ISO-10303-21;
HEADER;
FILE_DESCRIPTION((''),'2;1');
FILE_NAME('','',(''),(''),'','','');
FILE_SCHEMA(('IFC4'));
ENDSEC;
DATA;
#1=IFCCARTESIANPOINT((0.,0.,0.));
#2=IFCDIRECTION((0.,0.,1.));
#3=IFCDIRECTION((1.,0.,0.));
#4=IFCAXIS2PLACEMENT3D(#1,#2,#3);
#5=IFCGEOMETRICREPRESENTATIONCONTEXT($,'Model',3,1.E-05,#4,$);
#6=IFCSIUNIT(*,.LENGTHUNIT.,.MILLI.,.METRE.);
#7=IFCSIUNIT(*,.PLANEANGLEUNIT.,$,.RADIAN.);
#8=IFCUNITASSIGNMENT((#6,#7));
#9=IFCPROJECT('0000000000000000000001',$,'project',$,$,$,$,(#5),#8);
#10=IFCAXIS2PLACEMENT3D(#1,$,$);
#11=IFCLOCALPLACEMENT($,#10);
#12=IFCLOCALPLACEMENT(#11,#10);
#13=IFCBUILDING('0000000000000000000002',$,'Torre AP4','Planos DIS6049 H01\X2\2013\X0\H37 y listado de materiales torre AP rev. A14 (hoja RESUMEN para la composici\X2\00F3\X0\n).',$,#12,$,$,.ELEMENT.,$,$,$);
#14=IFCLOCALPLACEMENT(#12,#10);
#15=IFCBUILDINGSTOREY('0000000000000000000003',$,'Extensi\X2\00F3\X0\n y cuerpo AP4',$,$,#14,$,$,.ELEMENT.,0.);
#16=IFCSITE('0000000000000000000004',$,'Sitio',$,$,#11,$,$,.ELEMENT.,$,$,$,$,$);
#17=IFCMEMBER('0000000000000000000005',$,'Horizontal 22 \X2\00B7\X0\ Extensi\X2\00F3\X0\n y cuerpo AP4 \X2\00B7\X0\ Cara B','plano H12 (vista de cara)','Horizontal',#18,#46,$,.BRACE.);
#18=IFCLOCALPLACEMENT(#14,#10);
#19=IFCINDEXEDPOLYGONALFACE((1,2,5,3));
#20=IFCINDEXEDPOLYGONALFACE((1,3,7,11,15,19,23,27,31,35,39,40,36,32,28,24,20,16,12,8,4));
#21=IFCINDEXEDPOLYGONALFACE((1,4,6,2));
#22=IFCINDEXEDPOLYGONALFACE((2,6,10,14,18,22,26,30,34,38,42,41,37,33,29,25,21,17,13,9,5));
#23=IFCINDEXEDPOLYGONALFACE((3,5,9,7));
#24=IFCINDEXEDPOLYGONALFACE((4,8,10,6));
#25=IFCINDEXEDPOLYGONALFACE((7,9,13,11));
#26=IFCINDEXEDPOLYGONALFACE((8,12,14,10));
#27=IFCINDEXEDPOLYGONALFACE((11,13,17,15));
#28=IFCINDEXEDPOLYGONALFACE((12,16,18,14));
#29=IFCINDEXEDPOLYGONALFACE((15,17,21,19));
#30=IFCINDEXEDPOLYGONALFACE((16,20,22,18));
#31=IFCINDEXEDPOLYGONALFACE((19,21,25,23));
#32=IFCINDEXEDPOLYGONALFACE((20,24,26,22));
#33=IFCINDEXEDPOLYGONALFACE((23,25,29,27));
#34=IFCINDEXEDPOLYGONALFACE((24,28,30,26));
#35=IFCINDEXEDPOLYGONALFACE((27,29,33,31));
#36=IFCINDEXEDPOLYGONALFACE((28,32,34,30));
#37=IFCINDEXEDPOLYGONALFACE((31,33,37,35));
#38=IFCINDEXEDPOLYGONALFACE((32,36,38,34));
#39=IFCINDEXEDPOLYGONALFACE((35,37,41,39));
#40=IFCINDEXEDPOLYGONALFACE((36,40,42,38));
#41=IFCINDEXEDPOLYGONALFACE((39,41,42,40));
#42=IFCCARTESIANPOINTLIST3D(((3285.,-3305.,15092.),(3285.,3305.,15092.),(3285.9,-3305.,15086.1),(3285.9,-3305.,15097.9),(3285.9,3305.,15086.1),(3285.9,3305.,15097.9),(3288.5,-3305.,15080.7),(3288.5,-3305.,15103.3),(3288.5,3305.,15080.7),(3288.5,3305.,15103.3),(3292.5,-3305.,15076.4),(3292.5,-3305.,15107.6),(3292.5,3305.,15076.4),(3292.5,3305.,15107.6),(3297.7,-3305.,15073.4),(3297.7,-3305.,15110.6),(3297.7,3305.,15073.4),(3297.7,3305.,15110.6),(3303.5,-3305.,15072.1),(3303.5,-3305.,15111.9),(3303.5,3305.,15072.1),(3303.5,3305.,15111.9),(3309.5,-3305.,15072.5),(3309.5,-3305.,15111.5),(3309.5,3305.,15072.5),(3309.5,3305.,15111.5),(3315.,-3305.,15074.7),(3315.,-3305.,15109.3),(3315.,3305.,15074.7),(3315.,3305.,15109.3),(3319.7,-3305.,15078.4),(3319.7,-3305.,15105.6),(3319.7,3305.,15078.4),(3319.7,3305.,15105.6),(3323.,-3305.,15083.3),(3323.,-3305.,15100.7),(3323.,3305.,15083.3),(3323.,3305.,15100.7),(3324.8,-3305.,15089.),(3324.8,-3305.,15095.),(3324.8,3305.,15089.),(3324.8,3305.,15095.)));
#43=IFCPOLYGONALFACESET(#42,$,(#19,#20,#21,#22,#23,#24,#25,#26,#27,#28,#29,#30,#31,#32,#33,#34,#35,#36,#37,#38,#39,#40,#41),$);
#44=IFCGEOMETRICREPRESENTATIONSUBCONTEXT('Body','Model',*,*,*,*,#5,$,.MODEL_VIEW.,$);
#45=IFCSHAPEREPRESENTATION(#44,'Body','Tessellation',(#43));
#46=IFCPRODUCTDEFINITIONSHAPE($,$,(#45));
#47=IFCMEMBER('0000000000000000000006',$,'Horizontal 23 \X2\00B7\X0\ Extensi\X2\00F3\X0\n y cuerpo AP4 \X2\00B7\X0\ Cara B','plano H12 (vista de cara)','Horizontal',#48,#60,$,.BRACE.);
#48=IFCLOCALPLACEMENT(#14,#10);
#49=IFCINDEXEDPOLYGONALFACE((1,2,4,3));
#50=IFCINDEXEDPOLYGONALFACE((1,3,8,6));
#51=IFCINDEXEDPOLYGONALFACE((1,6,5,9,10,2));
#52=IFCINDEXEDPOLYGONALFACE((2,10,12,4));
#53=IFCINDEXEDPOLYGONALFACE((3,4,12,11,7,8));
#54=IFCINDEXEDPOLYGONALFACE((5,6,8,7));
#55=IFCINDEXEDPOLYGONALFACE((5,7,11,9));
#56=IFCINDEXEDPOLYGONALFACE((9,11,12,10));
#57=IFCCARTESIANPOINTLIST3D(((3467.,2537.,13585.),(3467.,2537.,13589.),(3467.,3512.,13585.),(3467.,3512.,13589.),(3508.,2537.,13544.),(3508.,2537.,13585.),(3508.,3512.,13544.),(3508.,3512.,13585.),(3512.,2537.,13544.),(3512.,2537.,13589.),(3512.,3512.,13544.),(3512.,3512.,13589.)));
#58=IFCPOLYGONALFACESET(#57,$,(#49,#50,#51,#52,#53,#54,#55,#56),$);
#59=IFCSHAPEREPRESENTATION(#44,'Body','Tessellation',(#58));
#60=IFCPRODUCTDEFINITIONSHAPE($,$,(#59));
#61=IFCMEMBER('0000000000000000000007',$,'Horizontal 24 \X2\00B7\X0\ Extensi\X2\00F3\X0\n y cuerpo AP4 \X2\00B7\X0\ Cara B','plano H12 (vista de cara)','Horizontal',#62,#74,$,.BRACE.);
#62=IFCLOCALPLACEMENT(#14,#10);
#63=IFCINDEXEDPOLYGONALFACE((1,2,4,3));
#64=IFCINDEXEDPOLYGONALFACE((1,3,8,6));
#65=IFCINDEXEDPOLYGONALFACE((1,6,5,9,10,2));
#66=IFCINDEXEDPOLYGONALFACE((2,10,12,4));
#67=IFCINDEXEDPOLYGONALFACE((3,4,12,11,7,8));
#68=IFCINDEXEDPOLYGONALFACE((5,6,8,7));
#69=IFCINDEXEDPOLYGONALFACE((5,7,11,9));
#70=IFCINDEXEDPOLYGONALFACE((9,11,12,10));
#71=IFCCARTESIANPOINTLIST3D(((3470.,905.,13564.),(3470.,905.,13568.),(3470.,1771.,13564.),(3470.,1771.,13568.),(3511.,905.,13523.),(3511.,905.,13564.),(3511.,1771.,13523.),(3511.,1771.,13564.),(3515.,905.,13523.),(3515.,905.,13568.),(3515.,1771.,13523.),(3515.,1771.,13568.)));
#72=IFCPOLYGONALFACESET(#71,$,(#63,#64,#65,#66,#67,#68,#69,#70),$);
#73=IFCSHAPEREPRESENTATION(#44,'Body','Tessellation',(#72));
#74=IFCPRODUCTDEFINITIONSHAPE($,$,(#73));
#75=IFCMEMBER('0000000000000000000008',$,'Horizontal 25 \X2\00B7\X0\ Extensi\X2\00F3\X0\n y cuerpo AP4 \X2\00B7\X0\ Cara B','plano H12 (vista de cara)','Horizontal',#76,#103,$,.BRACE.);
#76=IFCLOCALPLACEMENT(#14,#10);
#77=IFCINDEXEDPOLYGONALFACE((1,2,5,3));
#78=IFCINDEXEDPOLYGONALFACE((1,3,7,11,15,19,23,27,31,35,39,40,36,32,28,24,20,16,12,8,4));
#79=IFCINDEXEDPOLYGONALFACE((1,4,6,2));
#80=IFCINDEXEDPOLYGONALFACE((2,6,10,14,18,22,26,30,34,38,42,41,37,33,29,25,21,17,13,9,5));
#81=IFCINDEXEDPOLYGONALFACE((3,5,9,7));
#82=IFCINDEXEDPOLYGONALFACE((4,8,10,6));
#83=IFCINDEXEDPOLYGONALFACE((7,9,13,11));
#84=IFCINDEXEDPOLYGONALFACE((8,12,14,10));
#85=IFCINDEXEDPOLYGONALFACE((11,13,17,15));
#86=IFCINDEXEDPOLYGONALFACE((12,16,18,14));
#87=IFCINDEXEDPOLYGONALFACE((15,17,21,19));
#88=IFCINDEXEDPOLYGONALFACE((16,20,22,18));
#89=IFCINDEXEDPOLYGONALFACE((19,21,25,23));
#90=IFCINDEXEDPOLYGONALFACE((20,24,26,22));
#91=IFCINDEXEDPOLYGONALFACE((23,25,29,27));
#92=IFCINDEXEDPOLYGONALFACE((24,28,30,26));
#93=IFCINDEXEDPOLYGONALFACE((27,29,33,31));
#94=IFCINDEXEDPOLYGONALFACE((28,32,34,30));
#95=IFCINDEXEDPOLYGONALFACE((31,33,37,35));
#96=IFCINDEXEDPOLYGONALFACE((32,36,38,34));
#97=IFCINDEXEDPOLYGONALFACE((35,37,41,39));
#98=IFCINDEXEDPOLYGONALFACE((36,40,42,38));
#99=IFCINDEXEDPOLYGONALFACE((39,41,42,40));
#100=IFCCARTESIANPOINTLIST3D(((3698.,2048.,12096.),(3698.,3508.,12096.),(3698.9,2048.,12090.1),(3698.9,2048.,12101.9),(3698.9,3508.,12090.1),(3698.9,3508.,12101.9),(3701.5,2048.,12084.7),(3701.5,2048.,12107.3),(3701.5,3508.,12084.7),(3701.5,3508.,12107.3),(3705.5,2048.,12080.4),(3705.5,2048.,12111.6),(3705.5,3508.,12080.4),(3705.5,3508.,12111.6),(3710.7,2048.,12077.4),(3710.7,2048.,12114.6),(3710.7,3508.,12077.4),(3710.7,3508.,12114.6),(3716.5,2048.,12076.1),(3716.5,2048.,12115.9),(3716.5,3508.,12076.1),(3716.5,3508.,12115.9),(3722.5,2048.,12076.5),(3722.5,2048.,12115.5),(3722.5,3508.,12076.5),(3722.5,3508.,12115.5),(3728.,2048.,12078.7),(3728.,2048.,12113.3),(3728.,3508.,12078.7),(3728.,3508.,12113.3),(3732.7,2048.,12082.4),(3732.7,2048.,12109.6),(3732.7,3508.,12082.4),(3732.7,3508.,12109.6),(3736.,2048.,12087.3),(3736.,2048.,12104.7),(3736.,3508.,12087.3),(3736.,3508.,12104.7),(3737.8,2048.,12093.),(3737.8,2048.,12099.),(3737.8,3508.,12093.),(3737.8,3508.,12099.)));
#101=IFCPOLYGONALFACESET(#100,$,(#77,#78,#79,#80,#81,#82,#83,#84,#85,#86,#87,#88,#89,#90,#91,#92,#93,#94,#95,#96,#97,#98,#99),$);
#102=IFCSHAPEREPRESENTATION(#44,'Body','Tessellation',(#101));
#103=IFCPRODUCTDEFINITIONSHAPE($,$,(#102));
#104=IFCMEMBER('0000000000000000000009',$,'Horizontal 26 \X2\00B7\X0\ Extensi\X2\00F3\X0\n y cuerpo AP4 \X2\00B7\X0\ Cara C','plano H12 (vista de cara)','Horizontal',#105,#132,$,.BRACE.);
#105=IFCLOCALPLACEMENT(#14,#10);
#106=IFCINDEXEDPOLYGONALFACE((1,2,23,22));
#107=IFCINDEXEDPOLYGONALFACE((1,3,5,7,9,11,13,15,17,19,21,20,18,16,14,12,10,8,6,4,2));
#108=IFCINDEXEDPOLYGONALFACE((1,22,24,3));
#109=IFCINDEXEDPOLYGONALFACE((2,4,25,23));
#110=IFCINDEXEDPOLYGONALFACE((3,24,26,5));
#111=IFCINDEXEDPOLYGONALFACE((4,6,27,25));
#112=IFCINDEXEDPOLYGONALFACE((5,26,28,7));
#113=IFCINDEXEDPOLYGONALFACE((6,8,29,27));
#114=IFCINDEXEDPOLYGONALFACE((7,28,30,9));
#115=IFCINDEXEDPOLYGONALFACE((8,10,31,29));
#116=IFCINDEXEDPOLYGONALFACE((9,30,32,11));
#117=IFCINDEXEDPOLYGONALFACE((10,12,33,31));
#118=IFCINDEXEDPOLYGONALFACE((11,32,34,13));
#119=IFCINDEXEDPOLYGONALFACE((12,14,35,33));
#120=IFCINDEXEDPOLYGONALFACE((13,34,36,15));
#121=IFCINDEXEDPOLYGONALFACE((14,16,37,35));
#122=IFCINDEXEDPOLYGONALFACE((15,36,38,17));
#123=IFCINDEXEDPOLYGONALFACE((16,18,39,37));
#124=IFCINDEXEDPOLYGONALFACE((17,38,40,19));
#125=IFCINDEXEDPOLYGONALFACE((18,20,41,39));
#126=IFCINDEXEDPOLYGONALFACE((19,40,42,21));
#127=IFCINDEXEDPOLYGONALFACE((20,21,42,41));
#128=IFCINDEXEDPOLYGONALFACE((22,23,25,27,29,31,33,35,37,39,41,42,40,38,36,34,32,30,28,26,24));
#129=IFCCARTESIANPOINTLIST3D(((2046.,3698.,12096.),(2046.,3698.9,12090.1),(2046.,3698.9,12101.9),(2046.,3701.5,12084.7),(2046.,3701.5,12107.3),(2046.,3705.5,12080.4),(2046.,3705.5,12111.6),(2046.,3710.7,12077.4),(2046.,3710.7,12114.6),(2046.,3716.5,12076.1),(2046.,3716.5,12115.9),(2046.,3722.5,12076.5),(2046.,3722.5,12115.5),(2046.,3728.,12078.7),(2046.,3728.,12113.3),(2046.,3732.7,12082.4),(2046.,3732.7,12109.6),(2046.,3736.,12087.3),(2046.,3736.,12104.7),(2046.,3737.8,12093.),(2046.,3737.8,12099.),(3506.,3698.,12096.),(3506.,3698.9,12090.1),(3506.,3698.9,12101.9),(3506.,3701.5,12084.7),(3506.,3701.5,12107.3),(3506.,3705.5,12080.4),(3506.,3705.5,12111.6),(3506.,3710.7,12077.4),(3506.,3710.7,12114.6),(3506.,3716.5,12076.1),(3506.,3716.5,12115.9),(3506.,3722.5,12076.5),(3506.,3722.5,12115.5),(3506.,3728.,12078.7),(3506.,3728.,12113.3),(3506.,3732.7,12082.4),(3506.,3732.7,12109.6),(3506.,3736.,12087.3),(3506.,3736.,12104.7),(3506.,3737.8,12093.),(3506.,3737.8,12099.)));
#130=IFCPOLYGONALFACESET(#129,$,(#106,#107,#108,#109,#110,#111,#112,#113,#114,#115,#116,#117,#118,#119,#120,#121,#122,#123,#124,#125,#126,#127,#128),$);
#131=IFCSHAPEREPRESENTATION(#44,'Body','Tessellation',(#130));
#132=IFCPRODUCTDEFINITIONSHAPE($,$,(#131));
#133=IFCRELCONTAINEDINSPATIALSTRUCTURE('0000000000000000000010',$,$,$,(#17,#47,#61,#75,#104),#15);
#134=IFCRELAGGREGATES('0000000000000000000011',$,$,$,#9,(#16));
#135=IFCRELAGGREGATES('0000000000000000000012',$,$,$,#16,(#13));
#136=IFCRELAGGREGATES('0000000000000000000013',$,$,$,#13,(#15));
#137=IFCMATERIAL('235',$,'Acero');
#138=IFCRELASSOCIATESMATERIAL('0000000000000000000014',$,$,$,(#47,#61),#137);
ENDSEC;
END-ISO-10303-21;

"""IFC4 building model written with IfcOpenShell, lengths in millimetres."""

from ifc_helpers import new_model, si_unit, frame, frame_2d, origin, origin_with_axes, place, context, subcontext, project, spatial, circle, l_section, extrude, material, element, save


model = new_model("IFC4")

# Units and contexts
model_context = context("Model", 3, precision=1e-05, world=origin_with_axes())
body_context = subcontext(model_context, "Body", "Model", "MODEL_VIEW")
ifc_project = project(units=[si_unit("LENGTHUNIT", "METRE", prefix="MILLI"), si_unit("PLANEANGLEUNIT", "RADIAN")], contexts=[model_context])

# Site, building, storey
site_placement = place(None, origin())
site = spatial("IfcSite", under=ifc_project, at=site_placement, Name="Sitio", CompositionType="ELEMENT")
building_placement = place(site_placement, origin())
building = spatial("IfcBuilding", under=site, at=building_placement, Name="Torre AP4", Description="Planos DIS6049 H01–H37 y listado de materiales torre AP rev. A14 (hoja RESUMEN para la composición).", CompositionType="ELEMENT")
storey_placement = place(building_placement, origin())
storey = spatial("IfcBuildingStorey", under=building, at=storey_placement, Name="Extensión y cuerpo AP4", CompositionType="ELEMENT", Elevation=0.0)

# Members
ifc_material_1 = material(Name="235", Category="Acero")
member_1_placement = place(storey_placement, frame((3305.0, 3305.0, 15092.0), z_axis=(0.0, -1.0, 0.0), x_axis=(-1.0, 0.0, 0.0)))
element("IfcMember", 1, at=member_1_placement, inside=storey, Name="Horizontal 22 · Extensión y cuerpo AP4 · Cara B", Description="plano H12 (vista de cara)", ObjectType="Horizontal", PredefinedType="BRACE", context=body_context, shape_type="SweptSolid", body=[
    extrude(circle(Radius=20.0), None, (0.0, 0.0, 1.0), 6610.0),
])
member_2_placement = place(storey_placement, frame((3512.0, 3512.0, 13589.0), z_axis=(0.0, -1.0, 0.0), x_axis=(-1.0, 0.0, 0.0)))
element("IfcMember", 2, at=member_2_placement, inside=storey, material=ifc_material_1, Name="Horizontal 23 · Extensión y cuerpo AP4 · Cara B", Description="plano H12 (vista de cara)", ObjectType="Horizontal", PredefinedType="BRACE", context=body_context, shape_type="SweptSolid", body=[
    extrude(l_section(Depth=45.0, Width=45.0, Thickness=4.0, at=frame_2d((22.5, 22.5))), None, (0.0, 0.0, 1.0), 975.0),
])
member_3_placement = place(storey_placement, frame((3515.0, 1771.0, 13568.0), z_axis=(0.0, -1.0, 0.0), x_axis=(-1.0, 0.0, 0.0)))
element("IfcMember", 3, at=member_3_placement, inside=storey, material=ifc_material_1, Name="Horizontal 24 · Extensión y cuerpo AP4 · Cara B", Description="plano H12 (vista de cara)", ObjectType="Horizontal", PredefinedType="BRACE", context=body_context, shape_type="SweptSolid", body=[
    extrude(l_section(Depth=45.0, Width=45.0, Thickness=4.0, at=frame_2d((22.5, 22.5))), None, (0.0, 0.0, 1.0), 866.0),
])
for number, where, z_axis, x_axis, name in (
    (4, (3718.0, 3508.0, 12096.0), (0.0, -1.0, 0.0), (-1.0, 0.0, 0.0), "Horizontal 25 · Extensión y cuerpo AP4 · Cara B"),
    (5, (2046.0, 3718.0, 12096.0), (1.0, 0.0, 0.0), (0.0, -1.0, 0.0), "Horizontal 26 · Extensión y cuerpo AP4 · Cara C"),
):
    element("IfcMember", number, at=place(storey_placement, frame(where, z_axis=z_axis, x_axis=x_axis)), inside=storey, Name=name, Description="plano H12 (vista de cara)", ObjectType="Horizontal", PredefinedType="BRACE", context=body_context, shape_type="SweptSolid", body=[
        extrude(circle(Radius=20.0), None, (0.0, 0.0, 1.0), 1460.0),
    ])

save(model, "model.ifc")
